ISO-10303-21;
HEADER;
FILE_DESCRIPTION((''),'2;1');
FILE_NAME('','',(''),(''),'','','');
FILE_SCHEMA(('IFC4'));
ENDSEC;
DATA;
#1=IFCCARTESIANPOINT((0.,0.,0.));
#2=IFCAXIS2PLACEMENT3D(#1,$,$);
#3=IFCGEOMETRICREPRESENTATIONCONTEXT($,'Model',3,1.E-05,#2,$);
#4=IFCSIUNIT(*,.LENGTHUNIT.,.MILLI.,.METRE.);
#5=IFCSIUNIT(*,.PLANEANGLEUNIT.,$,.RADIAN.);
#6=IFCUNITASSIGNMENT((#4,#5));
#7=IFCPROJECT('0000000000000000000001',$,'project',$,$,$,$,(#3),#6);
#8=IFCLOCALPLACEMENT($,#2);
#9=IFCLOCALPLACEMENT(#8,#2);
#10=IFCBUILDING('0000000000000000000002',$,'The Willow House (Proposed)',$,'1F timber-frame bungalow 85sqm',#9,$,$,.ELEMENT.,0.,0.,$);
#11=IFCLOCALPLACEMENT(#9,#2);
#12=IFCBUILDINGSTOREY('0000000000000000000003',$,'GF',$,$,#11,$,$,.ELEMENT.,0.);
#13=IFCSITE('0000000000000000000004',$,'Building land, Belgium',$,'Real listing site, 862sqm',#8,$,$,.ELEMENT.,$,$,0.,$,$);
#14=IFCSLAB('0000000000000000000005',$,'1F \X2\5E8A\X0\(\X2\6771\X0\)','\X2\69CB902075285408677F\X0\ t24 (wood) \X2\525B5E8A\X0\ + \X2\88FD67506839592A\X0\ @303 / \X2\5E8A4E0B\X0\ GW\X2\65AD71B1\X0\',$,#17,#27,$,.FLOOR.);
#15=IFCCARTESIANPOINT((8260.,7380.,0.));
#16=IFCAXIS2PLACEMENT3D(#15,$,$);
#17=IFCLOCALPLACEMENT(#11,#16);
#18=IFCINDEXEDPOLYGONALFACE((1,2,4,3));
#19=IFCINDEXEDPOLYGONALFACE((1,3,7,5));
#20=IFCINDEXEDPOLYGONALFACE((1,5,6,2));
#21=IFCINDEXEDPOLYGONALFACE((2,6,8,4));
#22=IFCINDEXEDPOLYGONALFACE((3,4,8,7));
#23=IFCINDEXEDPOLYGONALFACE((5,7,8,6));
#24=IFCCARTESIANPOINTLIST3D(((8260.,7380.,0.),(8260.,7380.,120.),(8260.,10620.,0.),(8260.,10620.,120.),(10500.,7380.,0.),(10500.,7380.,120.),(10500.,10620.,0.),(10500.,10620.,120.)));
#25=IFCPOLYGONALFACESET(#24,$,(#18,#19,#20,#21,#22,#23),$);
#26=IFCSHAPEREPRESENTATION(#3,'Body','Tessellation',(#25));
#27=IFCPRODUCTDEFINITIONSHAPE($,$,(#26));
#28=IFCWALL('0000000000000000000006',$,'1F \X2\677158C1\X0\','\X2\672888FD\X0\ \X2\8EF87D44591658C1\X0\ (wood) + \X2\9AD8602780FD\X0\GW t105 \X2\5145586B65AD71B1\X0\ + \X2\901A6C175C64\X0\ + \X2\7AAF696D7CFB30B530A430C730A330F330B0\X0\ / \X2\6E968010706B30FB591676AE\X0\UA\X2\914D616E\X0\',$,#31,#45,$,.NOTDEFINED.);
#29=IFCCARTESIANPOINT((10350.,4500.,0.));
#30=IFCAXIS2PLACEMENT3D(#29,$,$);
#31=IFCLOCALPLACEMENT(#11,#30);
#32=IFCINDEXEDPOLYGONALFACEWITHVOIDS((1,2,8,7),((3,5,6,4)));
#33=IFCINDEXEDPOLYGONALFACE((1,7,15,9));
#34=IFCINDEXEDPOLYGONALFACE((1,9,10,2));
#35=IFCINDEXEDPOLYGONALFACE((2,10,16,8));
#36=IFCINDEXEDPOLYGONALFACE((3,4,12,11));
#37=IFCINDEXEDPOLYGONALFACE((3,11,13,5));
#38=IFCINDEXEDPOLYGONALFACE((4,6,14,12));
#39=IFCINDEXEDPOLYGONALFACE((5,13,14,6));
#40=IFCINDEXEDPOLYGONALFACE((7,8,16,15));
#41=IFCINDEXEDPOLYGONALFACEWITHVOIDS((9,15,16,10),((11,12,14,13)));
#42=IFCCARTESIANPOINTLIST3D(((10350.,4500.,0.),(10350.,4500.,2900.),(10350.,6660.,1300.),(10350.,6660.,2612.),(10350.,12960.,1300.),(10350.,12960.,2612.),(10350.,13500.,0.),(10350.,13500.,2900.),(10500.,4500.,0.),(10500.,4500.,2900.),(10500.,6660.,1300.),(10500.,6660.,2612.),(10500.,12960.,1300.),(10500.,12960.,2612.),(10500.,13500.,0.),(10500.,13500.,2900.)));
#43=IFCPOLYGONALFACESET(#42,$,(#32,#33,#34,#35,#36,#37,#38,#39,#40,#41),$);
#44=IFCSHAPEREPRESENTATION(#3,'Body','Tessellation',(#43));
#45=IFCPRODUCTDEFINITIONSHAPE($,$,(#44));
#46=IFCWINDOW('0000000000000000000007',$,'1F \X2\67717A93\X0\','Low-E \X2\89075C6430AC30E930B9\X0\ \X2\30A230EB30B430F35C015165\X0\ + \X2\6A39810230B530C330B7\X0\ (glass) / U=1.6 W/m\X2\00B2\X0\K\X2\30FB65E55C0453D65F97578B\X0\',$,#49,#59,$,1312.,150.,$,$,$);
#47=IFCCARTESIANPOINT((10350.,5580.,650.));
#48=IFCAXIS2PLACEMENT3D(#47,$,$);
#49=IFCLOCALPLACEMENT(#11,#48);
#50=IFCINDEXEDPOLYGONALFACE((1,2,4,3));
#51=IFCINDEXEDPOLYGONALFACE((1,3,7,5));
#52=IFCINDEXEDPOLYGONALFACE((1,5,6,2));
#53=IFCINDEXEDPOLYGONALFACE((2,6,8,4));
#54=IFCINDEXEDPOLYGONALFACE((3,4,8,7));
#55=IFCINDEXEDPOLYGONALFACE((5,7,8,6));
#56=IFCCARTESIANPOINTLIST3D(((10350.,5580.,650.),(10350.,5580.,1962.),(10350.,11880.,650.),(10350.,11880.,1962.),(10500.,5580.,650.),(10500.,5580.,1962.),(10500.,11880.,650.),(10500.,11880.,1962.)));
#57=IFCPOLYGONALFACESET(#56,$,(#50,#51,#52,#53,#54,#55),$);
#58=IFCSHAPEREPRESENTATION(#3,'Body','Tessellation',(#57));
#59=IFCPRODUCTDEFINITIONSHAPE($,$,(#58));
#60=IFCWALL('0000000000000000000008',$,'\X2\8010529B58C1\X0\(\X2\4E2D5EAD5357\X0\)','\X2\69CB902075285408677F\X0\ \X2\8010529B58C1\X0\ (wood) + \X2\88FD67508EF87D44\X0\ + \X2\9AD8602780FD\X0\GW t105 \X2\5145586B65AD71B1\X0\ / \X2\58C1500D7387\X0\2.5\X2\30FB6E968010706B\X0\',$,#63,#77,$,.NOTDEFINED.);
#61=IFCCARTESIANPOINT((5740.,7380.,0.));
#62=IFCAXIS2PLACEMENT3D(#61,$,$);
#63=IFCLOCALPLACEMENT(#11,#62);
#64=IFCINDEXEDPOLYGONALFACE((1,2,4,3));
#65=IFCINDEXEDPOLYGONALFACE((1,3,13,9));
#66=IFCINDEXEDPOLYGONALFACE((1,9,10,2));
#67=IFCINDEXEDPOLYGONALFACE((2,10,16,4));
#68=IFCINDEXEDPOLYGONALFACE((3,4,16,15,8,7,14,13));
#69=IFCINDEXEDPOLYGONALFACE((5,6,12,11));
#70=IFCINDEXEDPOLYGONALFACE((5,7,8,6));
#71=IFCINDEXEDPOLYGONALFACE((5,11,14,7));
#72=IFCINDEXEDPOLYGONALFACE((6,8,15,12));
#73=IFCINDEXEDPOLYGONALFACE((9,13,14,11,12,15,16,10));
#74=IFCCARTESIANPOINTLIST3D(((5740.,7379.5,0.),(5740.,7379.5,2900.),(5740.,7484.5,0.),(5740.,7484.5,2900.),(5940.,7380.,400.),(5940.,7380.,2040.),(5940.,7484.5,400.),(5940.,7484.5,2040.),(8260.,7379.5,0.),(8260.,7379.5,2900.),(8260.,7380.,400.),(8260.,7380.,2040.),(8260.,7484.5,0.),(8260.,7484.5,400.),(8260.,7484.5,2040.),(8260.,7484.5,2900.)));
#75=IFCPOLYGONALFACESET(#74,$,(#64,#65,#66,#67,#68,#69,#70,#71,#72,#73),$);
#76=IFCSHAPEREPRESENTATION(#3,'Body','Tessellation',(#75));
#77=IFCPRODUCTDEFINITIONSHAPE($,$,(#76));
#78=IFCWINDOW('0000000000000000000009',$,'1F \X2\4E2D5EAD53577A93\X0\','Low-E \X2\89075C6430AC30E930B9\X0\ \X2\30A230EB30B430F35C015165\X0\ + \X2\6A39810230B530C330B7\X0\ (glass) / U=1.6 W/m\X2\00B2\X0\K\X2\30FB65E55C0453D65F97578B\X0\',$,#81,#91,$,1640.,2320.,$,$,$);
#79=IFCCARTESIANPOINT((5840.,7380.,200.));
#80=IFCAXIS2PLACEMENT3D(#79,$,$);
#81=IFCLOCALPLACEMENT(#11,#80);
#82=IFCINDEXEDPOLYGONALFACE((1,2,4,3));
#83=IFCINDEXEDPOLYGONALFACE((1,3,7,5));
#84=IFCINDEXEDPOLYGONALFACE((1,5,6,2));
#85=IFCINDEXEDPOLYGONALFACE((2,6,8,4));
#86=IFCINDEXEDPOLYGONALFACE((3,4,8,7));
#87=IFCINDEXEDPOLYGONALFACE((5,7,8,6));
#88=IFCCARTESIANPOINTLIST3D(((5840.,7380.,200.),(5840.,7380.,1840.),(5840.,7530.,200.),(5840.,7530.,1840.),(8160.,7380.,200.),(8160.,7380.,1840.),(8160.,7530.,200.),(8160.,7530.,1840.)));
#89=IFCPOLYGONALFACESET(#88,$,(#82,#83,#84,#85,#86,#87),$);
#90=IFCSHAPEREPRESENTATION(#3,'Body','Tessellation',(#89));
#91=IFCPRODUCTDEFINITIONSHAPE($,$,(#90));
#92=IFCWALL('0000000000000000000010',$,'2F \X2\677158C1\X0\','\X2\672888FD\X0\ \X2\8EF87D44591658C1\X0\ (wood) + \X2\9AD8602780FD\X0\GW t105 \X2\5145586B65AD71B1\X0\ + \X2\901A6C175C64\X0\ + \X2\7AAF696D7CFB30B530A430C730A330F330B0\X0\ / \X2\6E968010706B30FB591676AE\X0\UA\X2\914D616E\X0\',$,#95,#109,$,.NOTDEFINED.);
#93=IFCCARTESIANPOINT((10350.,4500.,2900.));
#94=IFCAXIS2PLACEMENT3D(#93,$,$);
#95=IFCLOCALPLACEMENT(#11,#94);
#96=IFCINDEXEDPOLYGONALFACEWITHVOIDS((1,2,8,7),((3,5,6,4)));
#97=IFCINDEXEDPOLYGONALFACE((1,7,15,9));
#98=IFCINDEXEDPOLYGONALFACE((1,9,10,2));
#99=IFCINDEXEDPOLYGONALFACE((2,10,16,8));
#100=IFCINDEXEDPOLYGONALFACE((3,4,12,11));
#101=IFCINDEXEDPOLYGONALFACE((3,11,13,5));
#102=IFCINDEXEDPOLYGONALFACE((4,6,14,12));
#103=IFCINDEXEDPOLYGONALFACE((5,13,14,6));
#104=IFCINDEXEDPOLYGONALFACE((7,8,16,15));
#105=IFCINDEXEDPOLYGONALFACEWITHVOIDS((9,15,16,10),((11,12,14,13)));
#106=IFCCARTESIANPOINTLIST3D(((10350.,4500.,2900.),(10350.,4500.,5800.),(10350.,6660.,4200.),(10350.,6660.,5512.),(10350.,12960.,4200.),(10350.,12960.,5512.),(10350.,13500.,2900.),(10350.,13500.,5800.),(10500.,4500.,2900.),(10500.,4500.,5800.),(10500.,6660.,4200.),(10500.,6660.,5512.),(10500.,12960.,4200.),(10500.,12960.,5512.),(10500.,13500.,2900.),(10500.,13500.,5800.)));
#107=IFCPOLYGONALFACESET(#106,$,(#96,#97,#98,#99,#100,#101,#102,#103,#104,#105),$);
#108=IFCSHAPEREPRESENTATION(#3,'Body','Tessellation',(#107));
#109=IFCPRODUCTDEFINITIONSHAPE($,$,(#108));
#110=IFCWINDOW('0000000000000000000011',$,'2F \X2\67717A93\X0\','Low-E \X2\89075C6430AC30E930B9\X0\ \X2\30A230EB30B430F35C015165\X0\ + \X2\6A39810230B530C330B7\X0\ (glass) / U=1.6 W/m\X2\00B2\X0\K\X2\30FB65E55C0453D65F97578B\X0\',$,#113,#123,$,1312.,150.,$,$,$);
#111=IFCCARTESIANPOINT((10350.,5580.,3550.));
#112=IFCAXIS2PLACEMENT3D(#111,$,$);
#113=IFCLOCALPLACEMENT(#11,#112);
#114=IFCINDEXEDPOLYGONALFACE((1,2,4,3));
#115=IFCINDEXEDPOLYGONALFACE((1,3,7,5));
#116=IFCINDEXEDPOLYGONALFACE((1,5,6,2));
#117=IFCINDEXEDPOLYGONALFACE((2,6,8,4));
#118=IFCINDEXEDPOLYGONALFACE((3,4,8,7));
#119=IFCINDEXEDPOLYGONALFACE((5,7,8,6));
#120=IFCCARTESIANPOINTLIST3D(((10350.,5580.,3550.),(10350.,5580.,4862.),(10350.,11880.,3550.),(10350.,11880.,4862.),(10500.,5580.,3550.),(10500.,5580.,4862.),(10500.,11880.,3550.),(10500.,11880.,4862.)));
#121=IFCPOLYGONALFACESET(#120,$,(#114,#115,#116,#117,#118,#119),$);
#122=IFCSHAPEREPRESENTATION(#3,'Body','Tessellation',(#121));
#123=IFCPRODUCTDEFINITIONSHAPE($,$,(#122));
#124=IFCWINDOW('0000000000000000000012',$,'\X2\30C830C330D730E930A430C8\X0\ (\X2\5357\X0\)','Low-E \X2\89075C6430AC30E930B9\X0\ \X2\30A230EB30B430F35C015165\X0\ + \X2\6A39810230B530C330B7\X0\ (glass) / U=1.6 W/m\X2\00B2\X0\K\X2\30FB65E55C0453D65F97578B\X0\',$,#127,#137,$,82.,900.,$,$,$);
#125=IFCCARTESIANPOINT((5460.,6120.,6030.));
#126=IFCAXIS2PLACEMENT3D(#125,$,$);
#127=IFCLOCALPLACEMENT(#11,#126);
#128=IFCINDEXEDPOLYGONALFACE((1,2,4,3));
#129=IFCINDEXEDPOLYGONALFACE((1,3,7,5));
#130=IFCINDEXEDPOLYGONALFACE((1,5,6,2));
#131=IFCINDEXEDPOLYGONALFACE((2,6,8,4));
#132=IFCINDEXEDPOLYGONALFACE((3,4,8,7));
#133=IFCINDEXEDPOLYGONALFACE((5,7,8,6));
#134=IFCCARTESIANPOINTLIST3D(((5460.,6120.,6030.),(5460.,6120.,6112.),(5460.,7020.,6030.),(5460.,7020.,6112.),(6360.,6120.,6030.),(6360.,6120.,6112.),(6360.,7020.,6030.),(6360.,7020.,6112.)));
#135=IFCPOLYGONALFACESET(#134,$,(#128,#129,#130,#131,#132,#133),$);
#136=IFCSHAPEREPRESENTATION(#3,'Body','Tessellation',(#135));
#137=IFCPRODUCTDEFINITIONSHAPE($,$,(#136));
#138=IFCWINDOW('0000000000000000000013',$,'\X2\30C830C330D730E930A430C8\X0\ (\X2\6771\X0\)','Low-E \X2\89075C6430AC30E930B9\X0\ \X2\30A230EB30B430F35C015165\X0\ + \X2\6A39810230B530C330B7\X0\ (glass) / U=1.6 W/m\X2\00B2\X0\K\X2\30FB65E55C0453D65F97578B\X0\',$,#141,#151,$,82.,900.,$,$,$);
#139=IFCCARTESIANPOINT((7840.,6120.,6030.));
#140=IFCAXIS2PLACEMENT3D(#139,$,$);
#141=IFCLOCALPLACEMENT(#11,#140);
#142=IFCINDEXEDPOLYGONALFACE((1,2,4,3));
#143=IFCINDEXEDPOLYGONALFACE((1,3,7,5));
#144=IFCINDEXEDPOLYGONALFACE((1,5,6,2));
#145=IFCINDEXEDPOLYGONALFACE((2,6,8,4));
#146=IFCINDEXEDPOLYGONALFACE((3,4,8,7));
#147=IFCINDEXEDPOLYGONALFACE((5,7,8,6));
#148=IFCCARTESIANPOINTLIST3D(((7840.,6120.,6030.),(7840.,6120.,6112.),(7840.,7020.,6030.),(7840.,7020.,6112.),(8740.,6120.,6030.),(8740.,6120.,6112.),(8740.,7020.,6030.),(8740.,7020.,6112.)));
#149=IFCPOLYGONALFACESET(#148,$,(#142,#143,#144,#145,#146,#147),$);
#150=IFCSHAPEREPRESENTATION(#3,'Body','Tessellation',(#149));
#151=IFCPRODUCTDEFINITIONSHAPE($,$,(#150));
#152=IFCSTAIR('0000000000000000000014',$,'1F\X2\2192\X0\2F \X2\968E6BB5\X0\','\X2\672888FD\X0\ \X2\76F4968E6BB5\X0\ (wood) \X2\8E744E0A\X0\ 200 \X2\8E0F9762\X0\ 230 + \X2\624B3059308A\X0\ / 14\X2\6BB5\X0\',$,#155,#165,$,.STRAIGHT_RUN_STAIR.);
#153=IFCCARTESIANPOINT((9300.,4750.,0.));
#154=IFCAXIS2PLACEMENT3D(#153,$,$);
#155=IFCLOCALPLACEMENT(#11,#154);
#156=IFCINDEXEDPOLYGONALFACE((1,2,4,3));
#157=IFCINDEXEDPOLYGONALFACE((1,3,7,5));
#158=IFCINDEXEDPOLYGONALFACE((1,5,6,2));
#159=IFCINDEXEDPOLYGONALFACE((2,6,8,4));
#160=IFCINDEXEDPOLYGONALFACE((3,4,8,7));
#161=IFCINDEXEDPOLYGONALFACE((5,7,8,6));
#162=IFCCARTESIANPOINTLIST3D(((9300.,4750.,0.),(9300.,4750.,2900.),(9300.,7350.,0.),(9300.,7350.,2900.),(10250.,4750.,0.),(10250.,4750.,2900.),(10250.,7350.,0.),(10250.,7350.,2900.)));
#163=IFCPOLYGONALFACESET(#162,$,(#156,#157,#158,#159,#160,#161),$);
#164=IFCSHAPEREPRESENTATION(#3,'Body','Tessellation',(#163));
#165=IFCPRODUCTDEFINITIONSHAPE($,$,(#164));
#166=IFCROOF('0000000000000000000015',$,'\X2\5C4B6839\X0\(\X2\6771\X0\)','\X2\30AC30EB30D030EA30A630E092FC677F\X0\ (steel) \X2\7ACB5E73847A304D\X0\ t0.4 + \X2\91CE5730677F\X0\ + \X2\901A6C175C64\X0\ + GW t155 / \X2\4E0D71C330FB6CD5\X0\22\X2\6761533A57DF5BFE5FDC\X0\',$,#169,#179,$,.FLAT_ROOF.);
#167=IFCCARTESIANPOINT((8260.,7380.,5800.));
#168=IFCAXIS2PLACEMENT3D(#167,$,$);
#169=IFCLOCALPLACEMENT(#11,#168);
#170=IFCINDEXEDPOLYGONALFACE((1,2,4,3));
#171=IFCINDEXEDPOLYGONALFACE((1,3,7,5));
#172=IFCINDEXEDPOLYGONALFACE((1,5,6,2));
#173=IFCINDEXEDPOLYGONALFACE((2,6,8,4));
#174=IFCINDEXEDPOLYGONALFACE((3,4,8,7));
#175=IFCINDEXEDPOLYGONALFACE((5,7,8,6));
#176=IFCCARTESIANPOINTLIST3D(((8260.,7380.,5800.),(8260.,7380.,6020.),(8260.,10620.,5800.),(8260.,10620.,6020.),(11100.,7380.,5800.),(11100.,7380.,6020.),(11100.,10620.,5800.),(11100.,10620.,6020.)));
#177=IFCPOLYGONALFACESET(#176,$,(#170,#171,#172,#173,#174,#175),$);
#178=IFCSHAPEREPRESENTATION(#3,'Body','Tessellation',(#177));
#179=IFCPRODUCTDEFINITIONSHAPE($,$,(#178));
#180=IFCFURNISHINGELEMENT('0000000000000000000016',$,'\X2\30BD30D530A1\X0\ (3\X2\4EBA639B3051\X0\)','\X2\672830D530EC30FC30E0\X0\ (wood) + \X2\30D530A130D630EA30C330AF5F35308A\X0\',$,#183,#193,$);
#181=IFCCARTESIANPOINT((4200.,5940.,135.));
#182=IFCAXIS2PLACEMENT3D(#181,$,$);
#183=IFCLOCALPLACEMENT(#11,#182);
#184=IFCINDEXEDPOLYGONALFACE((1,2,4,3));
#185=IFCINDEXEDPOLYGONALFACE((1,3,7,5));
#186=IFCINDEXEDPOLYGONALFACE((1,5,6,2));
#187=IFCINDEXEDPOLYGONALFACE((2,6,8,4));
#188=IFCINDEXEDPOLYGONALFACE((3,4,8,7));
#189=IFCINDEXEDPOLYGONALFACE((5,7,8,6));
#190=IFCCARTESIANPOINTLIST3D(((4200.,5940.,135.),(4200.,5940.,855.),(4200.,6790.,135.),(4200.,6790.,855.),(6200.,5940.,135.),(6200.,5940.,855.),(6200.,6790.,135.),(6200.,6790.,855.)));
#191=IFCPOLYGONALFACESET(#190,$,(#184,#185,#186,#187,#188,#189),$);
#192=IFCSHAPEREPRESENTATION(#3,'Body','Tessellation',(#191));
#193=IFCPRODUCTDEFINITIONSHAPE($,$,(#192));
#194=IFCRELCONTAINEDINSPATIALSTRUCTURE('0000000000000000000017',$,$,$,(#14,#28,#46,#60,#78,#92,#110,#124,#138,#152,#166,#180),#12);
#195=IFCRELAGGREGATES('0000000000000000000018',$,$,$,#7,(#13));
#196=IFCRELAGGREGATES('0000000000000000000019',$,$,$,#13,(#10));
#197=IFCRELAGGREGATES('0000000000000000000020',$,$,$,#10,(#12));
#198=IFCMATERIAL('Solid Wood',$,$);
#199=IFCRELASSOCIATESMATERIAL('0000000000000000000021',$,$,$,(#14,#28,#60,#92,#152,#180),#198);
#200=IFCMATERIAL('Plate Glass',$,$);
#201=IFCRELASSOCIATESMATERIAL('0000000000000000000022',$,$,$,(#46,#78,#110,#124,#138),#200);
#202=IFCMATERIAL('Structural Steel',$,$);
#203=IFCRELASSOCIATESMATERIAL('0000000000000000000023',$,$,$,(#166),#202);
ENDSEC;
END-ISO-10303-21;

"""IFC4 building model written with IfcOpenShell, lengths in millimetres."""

from ifc_helpers import new_model, si_unit, frame, frame_2d, origin, place, context, project, spatial, rectangle, extrude, material, element, fill, save


model = new_model("IFC4")

# Units and contexts
model_context = context("Model", 3, precision=1e-05, world=origin())
ifc_project = project(units=[si_unit("LENGTHUNIT", "METRE", prefix="MILLI"), si_unit("PLANEANGLEUNIT", "RADIAN")], contexts=[model_context])

# Site, building, storey
site_placement = place(None, origin())
site = spatial("IfcSite", under=ifc_project, at=site_placement, Name="Building land, Belgium", ObjectType="Real listing site, 862sqm", CompositionType="ELEMENT", RefElevation=0.0)
building_placement = place(site_placement, origin())
building = spatial("IfcBuilding", under=site, at=building_placement, Name="The Willow House (Proposed)", ObjectType="1F timber-frame bungalow 85sqm", CompositionType="ELEMENT", ElevationOfRefHeight=0.0, ElevationOfTerrain=0.0)
storey_placement = place(building_placement, origin())
storey = spatial("IfcBuildingStorey", under=building, at=storey_placement, Name="GF", CompositionType="ELEMENT", Elevation=0.0)

# Slab
ifc_material_1 = material(Name="Solid Wood")
slab_placement = place(storey_placement, frame((8260.0, 7380.0, 0.0)))
element("IfcSlab", 1, at=slab_placement, inside=storey, material=ifc_material_1, Name="1F 床(東)", Description="構造用合板 t24 (wood) 剛床 + 製材根太 @303 / 床下 GW断熱", PredefinedType="FLOOR", context=model_context, shape_type="SweptSolid", body=[
    extrude(rectangle(XDim=2240.0, YDim=3240.0, at=frame_2d((1120.0, 1620.0))), frame((8260.0, 7380.0, 0.0)), (0.0, 0.0, 1.0), 120.0),
])

# Walls, openings, windows
wall_1_placement = place(storey_placement, frame((10350.0, 4500.0, 0.0)))
wall_1 = element("IfcWall", 2, at=wall_1_placement, inside=storey, material=ifc_material_1, Name="1F 東壁", Description="木製 軸組外壁 (wood) + 高性能GW t105 充填断熱 + 通気層 + 窯業系サイディング / 準耐火・外皮UA配慮", PredefinedType="NOTDEFINED", context=model_context, shape_type="SweptSolid", body=[
    extrude(rectangle(XDim=150.0, YDim=9000.0, at=frame_2d((75.0, 4500.0))), frame((10350.0, 4500.0, 0.0)), (0.0, 0.0, 1.0), 2900.0),
])
opening_1_placement = place(storey_placement, frame((10350.0, 5580.0, 650.0)))
opening_1 = element("IfcOpeningElement", 3, at=opening_1_placement, cuts=wall_1, PredefinedType="NOTDEFINED", context=model_context, shape_type="SweptSolid", body=[
    extrude(rectangle(XDim=150.0, YDim=6300.0, at=frame_2d((75.0, 3150.0))), frame((10350.0, 5580.0, 650.0)), (0.0, 0.0, 1.0), 1312.0),
])
ifc_material_2 = material(Name="Plate Glass")
window_1_placement = place(storey_placement, frame((10350.0, 5580.0, 650.0)))
window_1 = element("IfcWindow", 4, at=window_1_placement, inside=storey, material=ifc_material_2, Name="1F 東窓", Description="Low-E 複層ガラス アルゴン封入 + 樹脂サッシ (glass) / U=1.6 W/m²K・日射取得型", OverallHeight=1312.0, OverallWidth=150.0, context=model_context, shape_type="SweptSolid", body=[
    extrude(rectangle(XDim=150.0, YDim=6300.0, at=frame_2d((75.0, 3150.0))), frame((10350.0, 5580.0, 650.0)), (0.0, 0.0, 1.0), 1312.0),
])
fill(opening_1, window_1)
wall_2_placement = place(storey_placement, frame((5740.0, 7380.0, 0.0)))
wall_2 = element("IfcWall", 5, at=wall_2_placement, inside=storey, material=ifc_material_1, Name="耐力壁(中庭南)", Description="構造用合板 耐力壁 (wood) + 製材軸組 + 高性能GW t105 充填断熱 / 壁倍率2.5・準耐火", PredefinedType="NOTDEFINED", context=model_context, shape_type="SweptSolid", body=[
    extrude(rectangle(XDim=2520.0, YDim=105.0, at=frame_2d((1260.0, 52.0))), frame((5740.0, 7380.0, 0.0)), (0.0, 0.0, 1.0), 2900.0),
])
opening_2_placement = place(storey_placement, frame((5840.0, 7380.0, 200.0)))
opening_2 = element("IfcOpeningElement", 6, at=opening_2_placement, cuts=wall_2, PredefinedType="NOTDEFINED", context=model_context, shape_type="SweptSolid", body=[
    extrude(rectangle(XDim=2320.0, YDim=150.0, at=frame_2d((1160.0, 75.0))), frame((5840.0, 7380.0, 200.0)), (0.0, 0.0, 1.0), 1640.0),
])
window_2_placement = place(storey_placement, frame((5840.0, 7380.0, 200.0)))
window_2 = element("IfcWindow", 7, at=window_2_placement, inside=storey, material=ifc_material_2, Name="1F 中庭南窓", Description="Low-E 複層ガラス アルゴン封入 + 樹脂サッシ (glass) / U=1.6 W/m²K・日射取得型", OverallHeight=1640.0, OverallWidth=2320.0, context=model_context, shape_type="SweptSolid", body=[
    extrude(rectangle(XDim=2320.0, YDim=150.0, at=frame_2d((1160.0, 75.0))), frame((5840.0, 7380.0, 200.0)), (0.0, 0.0, 1.0), 1640.0),
])
fill(opening_2, window_2)

# Wall, opening, window
wall_3_placement = place(storey_placement, frame((10350.0, 4500.0, 2900.0)))
wall_3 = element("IfcWall", 8, at=wall_3_placement, inside=storey, material=ifc_material_1, Name="2F 東壁", Description="木製 軸組外壁 (wood) + 高性能GW t105 充填断熱 + 通気層 + 窯業系サイディング / 準耐火・外皮UA配慮", PredefinedType="NOTDEFINED", context=model_context, shape_type="SweptSolid", body=[
    extrude(rectangle(XDim=150.0, YDim=9000.0, at=frame_2d((75.0, 4500.0))), frame((10350.0, 4500.0, 2900.0)), (0.0, 0.0, 1.0), 2900.0),
])
opening_3_placement = place(storey_placement, frame((10350.0, 5580.0, 3550.0)))
opening_3 = element("IfcOpeningElement", 9, at=opening_3_placement, cuts=wall_3, PredefinedType="NOTDEFINED", context=model_context, shape_type="SweptSolid", body=[
    extrude(rectangle(XDim=150.0, YDim=6300.0, at=frame_2d((75.0, 3150.0))), frame((10350.0, 5580.0, 3550.0)), (0.0, 0.0, 1.0), 1312.0),
])
window_3_placement = place(storey_placement, frame((10350.0, 5580.0, 3550.0)))
window_3 = element("IfcWindow", 10, at=window_3_placement, inside=storey, material=ifc_material_2, Name="2F 東窓", Description="Low-E 複層ガラス アルゴン封入 + 樹脂サッシ (glass) / U=1.6 W/m²K・日射取得型", OverallHeight=1312.0, OverallWidth=150.0, context=model_context, shape_type="SweptSolid", body=[
    extrude(rectangle(XDim=150.0, YDim=6300.0, at=frame_2d((75.0, 3150.0))), frame((10350.0, 5580.0, 3550.0)), (0.0, 0.0, 1.0), 1312.0),
])
fill(opening_3, window_3)

# Windows
window_4_placement = place(storey_placement, frame((5460.0, 6120.0, 6030.0)))
element("IfcWindow", 11, at=window_4_placement, inside=storey, material=ifc_material_2, Name="トップライト (南)", Description="Low-E 複層ガラス アルゴン封入 + 樹脂サッシ (glass) / U=1.6 W/m²K・日射取得型", OverallHeight=82.0, OverallWidth=900.0, context=model_context, shape_type="SweptSolid", body=[
    extrude(rectangle(XDim=900.0, YDim=900.0, at=frame_2d((450.0, 450.0))), frame((5460.0, 6120.0, 6030.0)), (0.0, 0.0, 1.0), 82.0),
])
window_5_placement = place(storey_placement, frame((7840.0, 6120.0, 6030.0)))
element("IfcWindow", 12, at=window_5_placement, inside=storey, material=ifc_material_2, Name="トップライト (東)", Description="Low-E 複層ガラス アルゴン封入 + 樹脂サッシ (glass) / U=1.6 W/m²K・日射取得型", OverallHeight=82.0, OverallWidth=900.0, context=model_context, shape_type="SweptSolid", body=[
    extrude(rectangle(XDim=900.0, YDim=900.0, at=frame_2d((450.0, 450.0))), frame((7840.0, 6120.0, 6030.0)), (0.0, 0.0, 1.0), 82.0),
])

# Stair
stair_placement = place(storey_placement, frame((9300.0, 4750.0, 0.0)))
element("IfcStair", 13, at=stair_placement, inside=storey, material=ifc_material_1, Name="1F→2F 階段", Description="木製 直階段 (wood) 蹴上 200 踏面 230 + 手すり / 14段", PredefinedType="STRAIGHT_RUN_STAIR", context=model_context, shape_type="SweptSolid", body=[
    extrude(rectangle(XDim=950.0, YDim=2600.0, at=frame_2d((475.0, 1300.0))), frame((9300.0, 4750.0, 0.0)), (0.0, 0.0, 1.0), 2900.0),
])

# Roof
ifc_material_3 = material(Name="Structural Steel")
roof_placement = place(storey_placement, frame((8260.0, 7380.0, 5800.0)))
element("IfcRoof", 14, at=roof_placement, inside=storey, material=ifc_material_3, Name="屋根(東)", Description="ガルバリウム鋼板 (steel) 立平葺き t0.4 + 野地板 + 通気層 + GW t155 / 不燃・法22条区域対応", PredefinedType="FLAT_ROOF", context=model_context, shape_type="SweptSolid", body=[
    extrude(rectangle(XDim=2840.0, YDim=3240.0, at=frame_2d((1420.0, 1620.0))), frame((8260.0, 7380.0, 5800.0)), (0.0, 0.0, 1.0), 220.0),
])

# Furnishing element
furnishing_1_placement = place(storey_placement, frame((4200.0, 5940.0, 135.0)))
element("IfcFurnishingElement", 15, at=furnishing_1_placement, inside=storey, material=ifc_material_1, Name="ソファ (3人掛け)", Description="木フレーム (wood) + ファブリック張り", context=model_context, shape_type="SweptSolid", body=[
    extrude(rectangle(XDim=2000.0, YDim=850.0, at=frame_2d((1000.0, 425.0))), frame((4200.0, 5940.0, 135.0)), (0.0, 0.0, 1.0), 720.0),
])

save(model, "model.ifc")
